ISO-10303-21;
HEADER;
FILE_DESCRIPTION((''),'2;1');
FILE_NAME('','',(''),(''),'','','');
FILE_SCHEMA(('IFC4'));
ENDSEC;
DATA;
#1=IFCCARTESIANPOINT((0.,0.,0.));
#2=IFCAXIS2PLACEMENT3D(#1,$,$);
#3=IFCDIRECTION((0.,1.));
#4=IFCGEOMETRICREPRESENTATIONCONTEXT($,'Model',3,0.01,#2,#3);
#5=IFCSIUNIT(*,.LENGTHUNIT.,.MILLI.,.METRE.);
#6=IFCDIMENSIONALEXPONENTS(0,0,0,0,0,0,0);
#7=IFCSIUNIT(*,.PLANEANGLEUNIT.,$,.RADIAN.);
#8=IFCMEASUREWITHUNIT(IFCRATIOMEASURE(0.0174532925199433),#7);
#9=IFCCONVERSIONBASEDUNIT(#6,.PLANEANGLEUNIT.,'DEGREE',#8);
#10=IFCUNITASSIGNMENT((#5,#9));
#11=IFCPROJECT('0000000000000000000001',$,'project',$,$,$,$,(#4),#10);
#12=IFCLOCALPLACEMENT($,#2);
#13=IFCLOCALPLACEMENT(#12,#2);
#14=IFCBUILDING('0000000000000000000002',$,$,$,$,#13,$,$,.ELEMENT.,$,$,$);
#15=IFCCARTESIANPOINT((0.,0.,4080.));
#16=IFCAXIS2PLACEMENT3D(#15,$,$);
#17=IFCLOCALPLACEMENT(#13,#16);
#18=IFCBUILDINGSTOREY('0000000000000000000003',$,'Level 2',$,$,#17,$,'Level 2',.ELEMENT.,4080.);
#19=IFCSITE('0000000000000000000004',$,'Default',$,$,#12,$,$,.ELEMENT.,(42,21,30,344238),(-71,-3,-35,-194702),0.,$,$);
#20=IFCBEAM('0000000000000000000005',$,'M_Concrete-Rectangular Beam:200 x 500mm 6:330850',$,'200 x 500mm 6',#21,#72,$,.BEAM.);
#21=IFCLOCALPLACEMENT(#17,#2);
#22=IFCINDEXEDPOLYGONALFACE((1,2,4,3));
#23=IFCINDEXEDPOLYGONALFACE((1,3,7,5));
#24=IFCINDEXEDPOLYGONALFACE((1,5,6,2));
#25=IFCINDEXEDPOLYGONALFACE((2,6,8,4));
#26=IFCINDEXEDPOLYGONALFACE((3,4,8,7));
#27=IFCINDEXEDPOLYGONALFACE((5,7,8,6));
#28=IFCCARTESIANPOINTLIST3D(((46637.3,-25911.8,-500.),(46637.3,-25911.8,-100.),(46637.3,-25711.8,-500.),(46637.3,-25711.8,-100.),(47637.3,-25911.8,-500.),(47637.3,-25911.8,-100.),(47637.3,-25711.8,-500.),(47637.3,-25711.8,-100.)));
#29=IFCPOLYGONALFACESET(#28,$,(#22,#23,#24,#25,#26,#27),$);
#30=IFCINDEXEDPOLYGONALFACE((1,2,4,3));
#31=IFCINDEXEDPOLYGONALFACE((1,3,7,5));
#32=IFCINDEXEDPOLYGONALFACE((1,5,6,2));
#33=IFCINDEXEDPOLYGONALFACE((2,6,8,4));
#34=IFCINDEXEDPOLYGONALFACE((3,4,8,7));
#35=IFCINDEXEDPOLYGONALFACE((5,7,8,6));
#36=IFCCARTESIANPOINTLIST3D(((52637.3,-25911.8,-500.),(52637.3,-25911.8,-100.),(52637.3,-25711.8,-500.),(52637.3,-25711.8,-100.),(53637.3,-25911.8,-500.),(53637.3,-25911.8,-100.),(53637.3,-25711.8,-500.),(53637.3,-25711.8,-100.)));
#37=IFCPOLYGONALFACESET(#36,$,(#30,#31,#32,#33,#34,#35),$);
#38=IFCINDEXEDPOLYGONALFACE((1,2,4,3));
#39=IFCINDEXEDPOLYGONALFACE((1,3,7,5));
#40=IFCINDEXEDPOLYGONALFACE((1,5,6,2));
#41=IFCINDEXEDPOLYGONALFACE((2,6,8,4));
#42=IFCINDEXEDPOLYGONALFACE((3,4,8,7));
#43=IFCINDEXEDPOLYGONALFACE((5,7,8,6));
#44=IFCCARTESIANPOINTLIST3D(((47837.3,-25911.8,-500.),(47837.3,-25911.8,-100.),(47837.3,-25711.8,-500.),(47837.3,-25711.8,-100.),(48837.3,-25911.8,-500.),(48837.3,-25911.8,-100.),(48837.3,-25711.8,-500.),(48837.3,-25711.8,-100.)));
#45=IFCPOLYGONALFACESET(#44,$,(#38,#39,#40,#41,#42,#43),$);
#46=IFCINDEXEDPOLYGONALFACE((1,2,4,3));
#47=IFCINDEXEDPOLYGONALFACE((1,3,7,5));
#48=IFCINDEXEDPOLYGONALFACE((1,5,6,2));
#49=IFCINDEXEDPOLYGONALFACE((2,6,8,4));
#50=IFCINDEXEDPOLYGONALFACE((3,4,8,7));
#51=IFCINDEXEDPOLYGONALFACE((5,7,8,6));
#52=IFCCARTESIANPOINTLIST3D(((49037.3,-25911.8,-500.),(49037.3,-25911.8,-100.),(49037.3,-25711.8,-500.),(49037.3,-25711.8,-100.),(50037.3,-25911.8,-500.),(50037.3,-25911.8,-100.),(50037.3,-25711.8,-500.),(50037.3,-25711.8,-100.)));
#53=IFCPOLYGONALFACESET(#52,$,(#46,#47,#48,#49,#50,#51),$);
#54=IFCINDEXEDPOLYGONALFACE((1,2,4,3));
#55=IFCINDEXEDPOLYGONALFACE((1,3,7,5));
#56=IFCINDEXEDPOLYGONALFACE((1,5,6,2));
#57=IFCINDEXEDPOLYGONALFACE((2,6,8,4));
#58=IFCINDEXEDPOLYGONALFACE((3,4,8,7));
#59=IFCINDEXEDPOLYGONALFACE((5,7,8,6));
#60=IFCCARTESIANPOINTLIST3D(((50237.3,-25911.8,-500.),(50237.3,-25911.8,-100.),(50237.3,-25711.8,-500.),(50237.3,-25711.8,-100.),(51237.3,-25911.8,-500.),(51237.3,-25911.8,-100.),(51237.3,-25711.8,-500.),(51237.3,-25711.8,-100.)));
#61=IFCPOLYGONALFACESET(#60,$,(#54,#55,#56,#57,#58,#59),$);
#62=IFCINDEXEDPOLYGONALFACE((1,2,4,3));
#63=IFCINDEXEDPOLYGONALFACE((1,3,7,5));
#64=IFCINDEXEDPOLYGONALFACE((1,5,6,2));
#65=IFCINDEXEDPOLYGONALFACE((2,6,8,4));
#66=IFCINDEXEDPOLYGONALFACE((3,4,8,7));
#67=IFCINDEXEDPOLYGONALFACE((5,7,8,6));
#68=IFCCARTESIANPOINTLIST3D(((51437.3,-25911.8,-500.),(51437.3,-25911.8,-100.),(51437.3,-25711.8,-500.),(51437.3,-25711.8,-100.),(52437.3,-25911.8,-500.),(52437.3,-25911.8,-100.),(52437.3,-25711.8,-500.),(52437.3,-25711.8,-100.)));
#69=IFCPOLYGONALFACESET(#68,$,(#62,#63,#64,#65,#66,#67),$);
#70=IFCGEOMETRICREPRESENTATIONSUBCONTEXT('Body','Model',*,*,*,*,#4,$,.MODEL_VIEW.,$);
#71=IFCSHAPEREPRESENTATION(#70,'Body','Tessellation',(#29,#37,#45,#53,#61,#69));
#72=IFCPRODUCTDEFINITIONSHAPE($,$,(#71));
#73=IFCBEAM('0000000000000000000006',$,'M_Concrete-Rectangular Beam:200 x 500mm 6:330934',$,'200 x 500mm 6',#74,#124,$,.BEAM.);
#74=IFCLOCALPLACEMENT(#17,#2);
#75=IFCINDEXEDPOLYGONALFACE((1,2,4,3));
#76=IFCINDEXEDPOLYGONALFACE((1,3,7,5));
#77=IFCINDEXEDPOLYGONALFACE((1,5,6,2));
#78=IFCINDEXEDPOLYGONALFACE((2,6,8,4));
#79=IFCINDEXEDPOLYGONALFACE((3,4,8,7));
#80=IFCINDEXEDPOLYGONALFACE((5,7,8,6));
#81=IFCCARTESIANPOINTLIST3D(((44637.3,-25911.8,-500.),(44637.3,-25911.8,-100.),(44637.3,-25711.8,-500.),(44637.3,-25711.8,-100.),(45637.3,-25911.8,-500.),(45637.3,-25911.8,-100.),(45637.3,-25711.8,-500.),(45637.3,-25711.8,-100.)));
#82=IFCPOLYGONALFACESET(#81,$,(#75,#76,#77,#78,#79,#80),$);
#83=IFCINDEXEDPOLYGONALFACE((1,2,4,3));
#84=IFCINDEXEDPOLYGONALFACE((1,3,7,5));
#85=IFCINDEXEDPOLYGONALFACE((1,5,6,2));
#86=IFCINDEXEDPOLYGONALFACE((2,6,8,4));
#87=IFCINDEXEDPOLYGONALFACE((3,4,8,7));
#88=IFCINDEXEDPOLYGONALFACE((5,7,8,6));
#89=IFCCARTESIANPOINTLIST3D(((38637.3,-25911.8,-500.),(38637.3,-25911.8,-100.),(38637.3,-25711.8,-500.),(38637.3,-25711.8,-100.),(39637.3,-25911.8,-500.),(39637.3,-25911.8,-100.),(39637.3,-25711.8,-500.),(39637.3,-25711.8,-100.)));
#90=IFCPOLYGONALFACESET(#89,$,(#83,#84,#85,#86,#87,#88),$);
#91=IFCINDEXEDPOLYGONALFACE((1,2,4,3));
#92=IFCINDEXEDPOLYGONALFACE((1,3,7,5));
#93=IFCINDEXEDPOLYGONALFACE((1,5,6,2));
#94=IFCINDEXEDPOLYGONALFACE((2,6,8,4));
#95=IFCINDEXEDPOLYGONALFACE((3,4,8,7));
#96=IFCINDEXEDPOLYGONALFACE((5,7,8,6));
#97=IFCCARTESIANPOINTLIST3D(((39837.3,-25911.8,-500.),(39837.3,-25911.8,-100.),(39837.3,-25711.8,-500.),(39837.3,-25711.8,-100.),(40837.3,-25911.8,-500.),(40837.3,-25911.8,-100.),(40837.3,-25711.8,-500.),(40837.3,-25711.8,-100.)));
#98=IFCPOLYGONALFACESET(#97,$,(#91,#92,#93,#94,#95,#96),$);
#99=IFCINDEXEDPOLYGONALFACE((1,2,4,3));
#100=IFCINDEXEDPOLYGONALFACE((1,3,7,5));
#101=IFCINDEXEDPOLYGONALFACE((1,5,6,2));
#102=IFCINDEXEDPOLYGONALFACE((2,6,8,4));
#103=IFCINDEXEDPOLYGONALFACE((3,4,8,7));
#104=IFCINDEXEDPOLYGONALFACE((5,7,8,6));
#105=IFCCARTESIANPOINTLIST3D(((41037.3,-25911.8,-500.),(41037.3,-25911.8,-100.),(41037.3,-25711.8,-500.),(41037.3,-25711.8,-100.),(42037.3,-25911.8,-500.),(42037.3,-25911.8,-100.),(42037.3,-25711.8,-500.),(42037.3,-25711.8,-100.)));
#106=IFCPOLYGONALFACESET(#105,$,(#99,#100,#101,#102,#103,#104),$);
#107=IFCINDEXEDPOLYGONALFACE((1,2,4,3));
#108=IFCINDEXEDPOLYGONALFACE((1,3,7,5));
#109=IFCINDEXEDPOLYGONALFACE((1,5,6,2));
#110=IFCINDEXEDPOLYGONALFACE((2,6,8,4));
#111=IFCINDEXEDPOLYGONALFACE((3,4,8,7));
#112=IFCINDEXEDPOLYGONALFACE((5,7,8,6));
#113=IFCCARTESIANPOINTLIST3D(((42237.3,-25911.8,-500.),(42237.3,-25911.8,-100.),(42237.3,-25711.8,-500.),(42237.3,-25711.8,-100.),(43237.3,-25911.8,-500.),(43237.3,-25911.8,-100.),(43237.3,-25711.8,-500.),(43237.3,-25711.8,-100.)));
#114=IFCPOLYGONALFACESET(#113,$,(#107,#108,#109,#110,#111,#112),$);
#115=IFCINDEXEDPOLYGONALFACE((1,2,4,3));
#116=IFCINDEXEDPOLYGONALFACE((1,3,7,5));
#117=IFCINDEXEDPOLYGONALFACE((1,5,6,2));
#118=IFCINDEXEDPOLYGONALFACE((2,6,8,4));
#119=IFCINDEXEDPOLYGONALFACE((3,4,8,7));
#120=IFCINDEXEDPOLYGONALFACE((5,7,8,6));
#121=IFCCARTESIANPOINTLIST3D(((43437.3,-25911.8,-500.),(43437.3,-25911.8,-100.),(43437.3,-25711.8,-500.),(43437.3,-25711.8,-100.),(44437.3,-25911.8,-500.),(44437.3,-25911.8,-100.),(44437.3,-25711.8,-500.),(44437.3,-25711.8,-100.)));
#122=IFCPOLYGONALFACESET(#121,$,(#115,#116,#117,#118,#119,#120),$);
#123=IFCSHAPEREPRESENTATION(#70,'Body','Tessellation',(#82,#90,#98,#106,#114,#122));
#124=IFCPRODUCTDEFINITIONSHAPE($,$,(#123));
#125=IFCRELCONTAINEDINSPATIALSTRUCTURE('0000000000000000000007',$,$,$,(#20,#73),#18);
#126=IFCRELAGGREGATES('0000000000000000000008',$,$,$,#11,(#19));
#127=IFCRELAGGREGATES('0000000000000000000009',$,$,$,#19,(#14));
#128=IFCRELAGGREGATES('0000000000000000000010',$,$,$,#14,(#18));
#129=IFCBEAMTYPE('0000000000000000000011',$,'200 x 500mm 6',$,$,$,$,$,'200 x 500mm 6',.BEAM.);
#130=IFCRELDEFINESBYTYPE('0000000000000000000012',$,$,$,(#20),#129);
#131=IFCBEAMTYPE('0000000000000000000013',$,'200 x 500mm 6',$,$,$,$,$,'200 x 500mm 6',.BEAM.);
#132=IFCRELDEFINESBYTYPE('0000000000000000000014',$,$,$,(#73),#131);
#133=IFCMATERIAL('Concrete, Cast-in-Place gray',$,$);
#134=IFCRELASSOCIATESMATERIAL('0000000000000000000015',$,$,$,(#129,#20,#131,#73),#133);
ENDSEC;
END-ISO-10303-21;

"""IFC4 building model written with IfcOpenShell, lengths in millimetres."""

from ifc_helpers import new_model, entity, si_unit, converted_unit, direction, frame, frame_2d, origin, place, context, subcontext, project, spatial, rectangle, extrude, source, transform, mapped, material, type_object, type_shapes, element, save


model = new_model("IFC4")

# Units and contexts
model_context = context("Model", 3, precision=0.01, world=origin(), true_north=direction((0.0, 1.0)))
body_context = subcontext(model_context, "Body", "Model", "MODEL_VIEW")
ifc_project = project(units=[si_unit("LENGTHUNIT", "METRE", prefix="MILLI"), converted_unit("PLANEANGLEUNIT", "DEGREE", entity("IfcRatioMeasure", 0.0174532925199433), si_unit("PLANEANGLEUNIT", "RADIAN"), dimensions=[0, 0, 0, 0, 0, 0, 0])], contexts=[model_context])

# Site, building, storey
site_placement = place(None, origin())
site = spatial("IfcSite", under=ifc_project, at=site_placement, Name="Default", CompositionType="ELEMENT", RefLatitude=(42, 21, 30, 344238), RefLongitude=(-71, -3, -35, -194702), RefElevation=0.0)
building_placement = place(site_placement, origin())
building = spatial("IfcBuilding", under=site, at=building_placement, CompositionType="ELEMENT")
storey_placement = place(building_placement, frame((0.0, 0.0, 4080.0)))
storey = spatial("IfcBuildingStorey", under=building, at=storey_placement, Name="Level 2", LongName="Level 2", CompositionType="ELEMENT", Elevation=4080.0)

# Beams
ifc_material_1 = material(Name="Concrete, Cast-in-Place gray")
beam_type_1 = type_object("IfcBeamType", Name="200 x 500mm 6", ElementType="200 x 500mm 6", PredefinedType="BEAM", material=ifc_material_1)
shared_shape_1 = source(origin(), body_context, "Body", "SweptSolid", [
    extrude(rectangle(XDim=1000.0, YDim=200.0, at=frame_2d((-133.3, 0.0), x_axis=(1.0, 0.0))), frame((47270.6, -25811.8, 3580.0)), (0.0, 0.0, 1.0), 400.0),
    extrude(rectangle(XDim=1000.0, YDim=200.0, at=frame_2d((0.0, 0.0), x_axis=(1.0, 0.0))), frame((53137.3, -25811.8, 3580.0), z_axis=(0.0, 0.0, 1.0), x_axis=(-1.0, 0.0, 0.0)), (0.0, 0.0, 1.0), 400.0),
    extrude(rectangle(XDim=1000.0, YDim=200.0, at=frame_2d((0.0, 0.0), x_axis=(1.0, 0.0))), frame((48337.3, -25811.8, 3580.0)), (0.0, 0.0, 1.0), 400.0),
    extrude(rectangle(XDim=1000.0, YDim=200.0, at=frame_2d((0.0, 0.0), x_axis=(1.0, 0.0))), frame((49537.3, -25811.8, 3580.0)), (0.0, 0.0, 1.0), 400.0),
    extrude(rectangle(XDim=1000.0, YDim=200.0, at=frame_2d((0.0, 0.0), x_axis=(1.0, 0.0))), frame((50737.3, -25811.8, 3580.0)), (0.0, 0.0, 1.0), 400.0),
    extrude(rectangle(XDim=1000.0, YDim=200.0, at=frame_2d((0.0, 0.0), x_axis=(1.0, 0.0))), frame((51937.3, -25811.8, 3580.0)), (0.0, 0.0, 1.0), 400.0),
])
type_shapes(beam_type_1, [shared_shape_1])
beam_1_placement = place(storey_placement, frame((0.0, 0.0, -4080.0)))
element("IfcBeam", 1, at=beam_1_placement, inside=storey, type_object=beam_type_1, material=ifc_material_1, Name="M_Concrete-Rectangular Beam:200 x 500mm 6:330850", ObjectType="200 x 500mm 6", PredefinedType="BEAM", context=body_context, shape_type="MappedRepresentation", body=[
    mapped(shared_shape_1, transform((0.0, 0.0, 0.0), scale=1.0)),
])
beam_type_2 = type_object("IfcBeamType", Name="200 x 500mm 6", ElementType="200 x 500mm 6", PredefinedType="BEAM", material=ifc_material_1)
shared_shape_2 = source(origin(), body_context, "Body", "SweptSolid", [
    extrude(rectangle(XDim=1000.0, YDim=200.0, at=frame_2d((0.0, 0.0), x_axis=(1.0, 0.0))), frame((45137.3, -25811.8, 3580.0), z_axis=(0.0, 0.0, 1.0), x_axis=(-1.0, 0.0, 0.0)), (0.0, 0.0, 1.0), 400.0),
    extrude(rectangle(XDim=1000.0, YDim=200.0, at=frame_2d((0.0, 0.0), x_axis=(1.0, 0.0))), frame((39137.3, -25811.8, 3580.0)), (0.0, 0.0, 1.0), 400.0),
    extrude(rectangle(XDim=1000.0, YDim=200.0, at=frame_2d((0.0, 0.0), x_axis=(1.0, 0.0))), frame((40337.3, -25811.8, 3580.0)), (0.0, 0.0, 1.0), 400.0),
    extrude(rectangle(XDim=1000.0, YDim=200.0, at=frame_2d((0.0, 0.0), x_axis=(1.0, 0.0))), frame((41537.3, -25811.8, 3580.0)), (0.0, 0.0, 1.0), 400.0),
    extrude(rectangle(XDim=1000.0, YDim=200.0, at=frame_2d((0.0, 0.0), x_axis=(1.0, 0.0))), frame((42737.3, -25811.8, 3580.0)), (0.0, 0.0, 1.0), 400.0),
    extrude(rectangle(XDim=1000.0, YDim=200.0, at=frame_2d((0.0, 0.0), x_axis=(1.0, 0.0))), frame((43937.3, -25811.8, 3580.0)), (0.0, 0.0, 1.0), 400.0),
])
type_shapes(beam_type_2, [shared_shape_2])
beam_2_placement = place(storey_placement, frame((0.0, 0.0, -4080.0)))
element("IfcBeam", 2, at=beam_2_placement, inside=storey, type_object=beam_type_2, material=ifc_material_1, Name="M_Concrete-Rectangular Beam:200 x 500mm 6:330934", ObjectType="200 x 500mm 6", PredefinedType="BEAM", context=body_context, shape_type="MappedRepresentation", body=[
    mapped(shared_shape_2, transform((0.0, 0.0, 0.0), scale=1.0)),
])

save(model, "model.ifc")
